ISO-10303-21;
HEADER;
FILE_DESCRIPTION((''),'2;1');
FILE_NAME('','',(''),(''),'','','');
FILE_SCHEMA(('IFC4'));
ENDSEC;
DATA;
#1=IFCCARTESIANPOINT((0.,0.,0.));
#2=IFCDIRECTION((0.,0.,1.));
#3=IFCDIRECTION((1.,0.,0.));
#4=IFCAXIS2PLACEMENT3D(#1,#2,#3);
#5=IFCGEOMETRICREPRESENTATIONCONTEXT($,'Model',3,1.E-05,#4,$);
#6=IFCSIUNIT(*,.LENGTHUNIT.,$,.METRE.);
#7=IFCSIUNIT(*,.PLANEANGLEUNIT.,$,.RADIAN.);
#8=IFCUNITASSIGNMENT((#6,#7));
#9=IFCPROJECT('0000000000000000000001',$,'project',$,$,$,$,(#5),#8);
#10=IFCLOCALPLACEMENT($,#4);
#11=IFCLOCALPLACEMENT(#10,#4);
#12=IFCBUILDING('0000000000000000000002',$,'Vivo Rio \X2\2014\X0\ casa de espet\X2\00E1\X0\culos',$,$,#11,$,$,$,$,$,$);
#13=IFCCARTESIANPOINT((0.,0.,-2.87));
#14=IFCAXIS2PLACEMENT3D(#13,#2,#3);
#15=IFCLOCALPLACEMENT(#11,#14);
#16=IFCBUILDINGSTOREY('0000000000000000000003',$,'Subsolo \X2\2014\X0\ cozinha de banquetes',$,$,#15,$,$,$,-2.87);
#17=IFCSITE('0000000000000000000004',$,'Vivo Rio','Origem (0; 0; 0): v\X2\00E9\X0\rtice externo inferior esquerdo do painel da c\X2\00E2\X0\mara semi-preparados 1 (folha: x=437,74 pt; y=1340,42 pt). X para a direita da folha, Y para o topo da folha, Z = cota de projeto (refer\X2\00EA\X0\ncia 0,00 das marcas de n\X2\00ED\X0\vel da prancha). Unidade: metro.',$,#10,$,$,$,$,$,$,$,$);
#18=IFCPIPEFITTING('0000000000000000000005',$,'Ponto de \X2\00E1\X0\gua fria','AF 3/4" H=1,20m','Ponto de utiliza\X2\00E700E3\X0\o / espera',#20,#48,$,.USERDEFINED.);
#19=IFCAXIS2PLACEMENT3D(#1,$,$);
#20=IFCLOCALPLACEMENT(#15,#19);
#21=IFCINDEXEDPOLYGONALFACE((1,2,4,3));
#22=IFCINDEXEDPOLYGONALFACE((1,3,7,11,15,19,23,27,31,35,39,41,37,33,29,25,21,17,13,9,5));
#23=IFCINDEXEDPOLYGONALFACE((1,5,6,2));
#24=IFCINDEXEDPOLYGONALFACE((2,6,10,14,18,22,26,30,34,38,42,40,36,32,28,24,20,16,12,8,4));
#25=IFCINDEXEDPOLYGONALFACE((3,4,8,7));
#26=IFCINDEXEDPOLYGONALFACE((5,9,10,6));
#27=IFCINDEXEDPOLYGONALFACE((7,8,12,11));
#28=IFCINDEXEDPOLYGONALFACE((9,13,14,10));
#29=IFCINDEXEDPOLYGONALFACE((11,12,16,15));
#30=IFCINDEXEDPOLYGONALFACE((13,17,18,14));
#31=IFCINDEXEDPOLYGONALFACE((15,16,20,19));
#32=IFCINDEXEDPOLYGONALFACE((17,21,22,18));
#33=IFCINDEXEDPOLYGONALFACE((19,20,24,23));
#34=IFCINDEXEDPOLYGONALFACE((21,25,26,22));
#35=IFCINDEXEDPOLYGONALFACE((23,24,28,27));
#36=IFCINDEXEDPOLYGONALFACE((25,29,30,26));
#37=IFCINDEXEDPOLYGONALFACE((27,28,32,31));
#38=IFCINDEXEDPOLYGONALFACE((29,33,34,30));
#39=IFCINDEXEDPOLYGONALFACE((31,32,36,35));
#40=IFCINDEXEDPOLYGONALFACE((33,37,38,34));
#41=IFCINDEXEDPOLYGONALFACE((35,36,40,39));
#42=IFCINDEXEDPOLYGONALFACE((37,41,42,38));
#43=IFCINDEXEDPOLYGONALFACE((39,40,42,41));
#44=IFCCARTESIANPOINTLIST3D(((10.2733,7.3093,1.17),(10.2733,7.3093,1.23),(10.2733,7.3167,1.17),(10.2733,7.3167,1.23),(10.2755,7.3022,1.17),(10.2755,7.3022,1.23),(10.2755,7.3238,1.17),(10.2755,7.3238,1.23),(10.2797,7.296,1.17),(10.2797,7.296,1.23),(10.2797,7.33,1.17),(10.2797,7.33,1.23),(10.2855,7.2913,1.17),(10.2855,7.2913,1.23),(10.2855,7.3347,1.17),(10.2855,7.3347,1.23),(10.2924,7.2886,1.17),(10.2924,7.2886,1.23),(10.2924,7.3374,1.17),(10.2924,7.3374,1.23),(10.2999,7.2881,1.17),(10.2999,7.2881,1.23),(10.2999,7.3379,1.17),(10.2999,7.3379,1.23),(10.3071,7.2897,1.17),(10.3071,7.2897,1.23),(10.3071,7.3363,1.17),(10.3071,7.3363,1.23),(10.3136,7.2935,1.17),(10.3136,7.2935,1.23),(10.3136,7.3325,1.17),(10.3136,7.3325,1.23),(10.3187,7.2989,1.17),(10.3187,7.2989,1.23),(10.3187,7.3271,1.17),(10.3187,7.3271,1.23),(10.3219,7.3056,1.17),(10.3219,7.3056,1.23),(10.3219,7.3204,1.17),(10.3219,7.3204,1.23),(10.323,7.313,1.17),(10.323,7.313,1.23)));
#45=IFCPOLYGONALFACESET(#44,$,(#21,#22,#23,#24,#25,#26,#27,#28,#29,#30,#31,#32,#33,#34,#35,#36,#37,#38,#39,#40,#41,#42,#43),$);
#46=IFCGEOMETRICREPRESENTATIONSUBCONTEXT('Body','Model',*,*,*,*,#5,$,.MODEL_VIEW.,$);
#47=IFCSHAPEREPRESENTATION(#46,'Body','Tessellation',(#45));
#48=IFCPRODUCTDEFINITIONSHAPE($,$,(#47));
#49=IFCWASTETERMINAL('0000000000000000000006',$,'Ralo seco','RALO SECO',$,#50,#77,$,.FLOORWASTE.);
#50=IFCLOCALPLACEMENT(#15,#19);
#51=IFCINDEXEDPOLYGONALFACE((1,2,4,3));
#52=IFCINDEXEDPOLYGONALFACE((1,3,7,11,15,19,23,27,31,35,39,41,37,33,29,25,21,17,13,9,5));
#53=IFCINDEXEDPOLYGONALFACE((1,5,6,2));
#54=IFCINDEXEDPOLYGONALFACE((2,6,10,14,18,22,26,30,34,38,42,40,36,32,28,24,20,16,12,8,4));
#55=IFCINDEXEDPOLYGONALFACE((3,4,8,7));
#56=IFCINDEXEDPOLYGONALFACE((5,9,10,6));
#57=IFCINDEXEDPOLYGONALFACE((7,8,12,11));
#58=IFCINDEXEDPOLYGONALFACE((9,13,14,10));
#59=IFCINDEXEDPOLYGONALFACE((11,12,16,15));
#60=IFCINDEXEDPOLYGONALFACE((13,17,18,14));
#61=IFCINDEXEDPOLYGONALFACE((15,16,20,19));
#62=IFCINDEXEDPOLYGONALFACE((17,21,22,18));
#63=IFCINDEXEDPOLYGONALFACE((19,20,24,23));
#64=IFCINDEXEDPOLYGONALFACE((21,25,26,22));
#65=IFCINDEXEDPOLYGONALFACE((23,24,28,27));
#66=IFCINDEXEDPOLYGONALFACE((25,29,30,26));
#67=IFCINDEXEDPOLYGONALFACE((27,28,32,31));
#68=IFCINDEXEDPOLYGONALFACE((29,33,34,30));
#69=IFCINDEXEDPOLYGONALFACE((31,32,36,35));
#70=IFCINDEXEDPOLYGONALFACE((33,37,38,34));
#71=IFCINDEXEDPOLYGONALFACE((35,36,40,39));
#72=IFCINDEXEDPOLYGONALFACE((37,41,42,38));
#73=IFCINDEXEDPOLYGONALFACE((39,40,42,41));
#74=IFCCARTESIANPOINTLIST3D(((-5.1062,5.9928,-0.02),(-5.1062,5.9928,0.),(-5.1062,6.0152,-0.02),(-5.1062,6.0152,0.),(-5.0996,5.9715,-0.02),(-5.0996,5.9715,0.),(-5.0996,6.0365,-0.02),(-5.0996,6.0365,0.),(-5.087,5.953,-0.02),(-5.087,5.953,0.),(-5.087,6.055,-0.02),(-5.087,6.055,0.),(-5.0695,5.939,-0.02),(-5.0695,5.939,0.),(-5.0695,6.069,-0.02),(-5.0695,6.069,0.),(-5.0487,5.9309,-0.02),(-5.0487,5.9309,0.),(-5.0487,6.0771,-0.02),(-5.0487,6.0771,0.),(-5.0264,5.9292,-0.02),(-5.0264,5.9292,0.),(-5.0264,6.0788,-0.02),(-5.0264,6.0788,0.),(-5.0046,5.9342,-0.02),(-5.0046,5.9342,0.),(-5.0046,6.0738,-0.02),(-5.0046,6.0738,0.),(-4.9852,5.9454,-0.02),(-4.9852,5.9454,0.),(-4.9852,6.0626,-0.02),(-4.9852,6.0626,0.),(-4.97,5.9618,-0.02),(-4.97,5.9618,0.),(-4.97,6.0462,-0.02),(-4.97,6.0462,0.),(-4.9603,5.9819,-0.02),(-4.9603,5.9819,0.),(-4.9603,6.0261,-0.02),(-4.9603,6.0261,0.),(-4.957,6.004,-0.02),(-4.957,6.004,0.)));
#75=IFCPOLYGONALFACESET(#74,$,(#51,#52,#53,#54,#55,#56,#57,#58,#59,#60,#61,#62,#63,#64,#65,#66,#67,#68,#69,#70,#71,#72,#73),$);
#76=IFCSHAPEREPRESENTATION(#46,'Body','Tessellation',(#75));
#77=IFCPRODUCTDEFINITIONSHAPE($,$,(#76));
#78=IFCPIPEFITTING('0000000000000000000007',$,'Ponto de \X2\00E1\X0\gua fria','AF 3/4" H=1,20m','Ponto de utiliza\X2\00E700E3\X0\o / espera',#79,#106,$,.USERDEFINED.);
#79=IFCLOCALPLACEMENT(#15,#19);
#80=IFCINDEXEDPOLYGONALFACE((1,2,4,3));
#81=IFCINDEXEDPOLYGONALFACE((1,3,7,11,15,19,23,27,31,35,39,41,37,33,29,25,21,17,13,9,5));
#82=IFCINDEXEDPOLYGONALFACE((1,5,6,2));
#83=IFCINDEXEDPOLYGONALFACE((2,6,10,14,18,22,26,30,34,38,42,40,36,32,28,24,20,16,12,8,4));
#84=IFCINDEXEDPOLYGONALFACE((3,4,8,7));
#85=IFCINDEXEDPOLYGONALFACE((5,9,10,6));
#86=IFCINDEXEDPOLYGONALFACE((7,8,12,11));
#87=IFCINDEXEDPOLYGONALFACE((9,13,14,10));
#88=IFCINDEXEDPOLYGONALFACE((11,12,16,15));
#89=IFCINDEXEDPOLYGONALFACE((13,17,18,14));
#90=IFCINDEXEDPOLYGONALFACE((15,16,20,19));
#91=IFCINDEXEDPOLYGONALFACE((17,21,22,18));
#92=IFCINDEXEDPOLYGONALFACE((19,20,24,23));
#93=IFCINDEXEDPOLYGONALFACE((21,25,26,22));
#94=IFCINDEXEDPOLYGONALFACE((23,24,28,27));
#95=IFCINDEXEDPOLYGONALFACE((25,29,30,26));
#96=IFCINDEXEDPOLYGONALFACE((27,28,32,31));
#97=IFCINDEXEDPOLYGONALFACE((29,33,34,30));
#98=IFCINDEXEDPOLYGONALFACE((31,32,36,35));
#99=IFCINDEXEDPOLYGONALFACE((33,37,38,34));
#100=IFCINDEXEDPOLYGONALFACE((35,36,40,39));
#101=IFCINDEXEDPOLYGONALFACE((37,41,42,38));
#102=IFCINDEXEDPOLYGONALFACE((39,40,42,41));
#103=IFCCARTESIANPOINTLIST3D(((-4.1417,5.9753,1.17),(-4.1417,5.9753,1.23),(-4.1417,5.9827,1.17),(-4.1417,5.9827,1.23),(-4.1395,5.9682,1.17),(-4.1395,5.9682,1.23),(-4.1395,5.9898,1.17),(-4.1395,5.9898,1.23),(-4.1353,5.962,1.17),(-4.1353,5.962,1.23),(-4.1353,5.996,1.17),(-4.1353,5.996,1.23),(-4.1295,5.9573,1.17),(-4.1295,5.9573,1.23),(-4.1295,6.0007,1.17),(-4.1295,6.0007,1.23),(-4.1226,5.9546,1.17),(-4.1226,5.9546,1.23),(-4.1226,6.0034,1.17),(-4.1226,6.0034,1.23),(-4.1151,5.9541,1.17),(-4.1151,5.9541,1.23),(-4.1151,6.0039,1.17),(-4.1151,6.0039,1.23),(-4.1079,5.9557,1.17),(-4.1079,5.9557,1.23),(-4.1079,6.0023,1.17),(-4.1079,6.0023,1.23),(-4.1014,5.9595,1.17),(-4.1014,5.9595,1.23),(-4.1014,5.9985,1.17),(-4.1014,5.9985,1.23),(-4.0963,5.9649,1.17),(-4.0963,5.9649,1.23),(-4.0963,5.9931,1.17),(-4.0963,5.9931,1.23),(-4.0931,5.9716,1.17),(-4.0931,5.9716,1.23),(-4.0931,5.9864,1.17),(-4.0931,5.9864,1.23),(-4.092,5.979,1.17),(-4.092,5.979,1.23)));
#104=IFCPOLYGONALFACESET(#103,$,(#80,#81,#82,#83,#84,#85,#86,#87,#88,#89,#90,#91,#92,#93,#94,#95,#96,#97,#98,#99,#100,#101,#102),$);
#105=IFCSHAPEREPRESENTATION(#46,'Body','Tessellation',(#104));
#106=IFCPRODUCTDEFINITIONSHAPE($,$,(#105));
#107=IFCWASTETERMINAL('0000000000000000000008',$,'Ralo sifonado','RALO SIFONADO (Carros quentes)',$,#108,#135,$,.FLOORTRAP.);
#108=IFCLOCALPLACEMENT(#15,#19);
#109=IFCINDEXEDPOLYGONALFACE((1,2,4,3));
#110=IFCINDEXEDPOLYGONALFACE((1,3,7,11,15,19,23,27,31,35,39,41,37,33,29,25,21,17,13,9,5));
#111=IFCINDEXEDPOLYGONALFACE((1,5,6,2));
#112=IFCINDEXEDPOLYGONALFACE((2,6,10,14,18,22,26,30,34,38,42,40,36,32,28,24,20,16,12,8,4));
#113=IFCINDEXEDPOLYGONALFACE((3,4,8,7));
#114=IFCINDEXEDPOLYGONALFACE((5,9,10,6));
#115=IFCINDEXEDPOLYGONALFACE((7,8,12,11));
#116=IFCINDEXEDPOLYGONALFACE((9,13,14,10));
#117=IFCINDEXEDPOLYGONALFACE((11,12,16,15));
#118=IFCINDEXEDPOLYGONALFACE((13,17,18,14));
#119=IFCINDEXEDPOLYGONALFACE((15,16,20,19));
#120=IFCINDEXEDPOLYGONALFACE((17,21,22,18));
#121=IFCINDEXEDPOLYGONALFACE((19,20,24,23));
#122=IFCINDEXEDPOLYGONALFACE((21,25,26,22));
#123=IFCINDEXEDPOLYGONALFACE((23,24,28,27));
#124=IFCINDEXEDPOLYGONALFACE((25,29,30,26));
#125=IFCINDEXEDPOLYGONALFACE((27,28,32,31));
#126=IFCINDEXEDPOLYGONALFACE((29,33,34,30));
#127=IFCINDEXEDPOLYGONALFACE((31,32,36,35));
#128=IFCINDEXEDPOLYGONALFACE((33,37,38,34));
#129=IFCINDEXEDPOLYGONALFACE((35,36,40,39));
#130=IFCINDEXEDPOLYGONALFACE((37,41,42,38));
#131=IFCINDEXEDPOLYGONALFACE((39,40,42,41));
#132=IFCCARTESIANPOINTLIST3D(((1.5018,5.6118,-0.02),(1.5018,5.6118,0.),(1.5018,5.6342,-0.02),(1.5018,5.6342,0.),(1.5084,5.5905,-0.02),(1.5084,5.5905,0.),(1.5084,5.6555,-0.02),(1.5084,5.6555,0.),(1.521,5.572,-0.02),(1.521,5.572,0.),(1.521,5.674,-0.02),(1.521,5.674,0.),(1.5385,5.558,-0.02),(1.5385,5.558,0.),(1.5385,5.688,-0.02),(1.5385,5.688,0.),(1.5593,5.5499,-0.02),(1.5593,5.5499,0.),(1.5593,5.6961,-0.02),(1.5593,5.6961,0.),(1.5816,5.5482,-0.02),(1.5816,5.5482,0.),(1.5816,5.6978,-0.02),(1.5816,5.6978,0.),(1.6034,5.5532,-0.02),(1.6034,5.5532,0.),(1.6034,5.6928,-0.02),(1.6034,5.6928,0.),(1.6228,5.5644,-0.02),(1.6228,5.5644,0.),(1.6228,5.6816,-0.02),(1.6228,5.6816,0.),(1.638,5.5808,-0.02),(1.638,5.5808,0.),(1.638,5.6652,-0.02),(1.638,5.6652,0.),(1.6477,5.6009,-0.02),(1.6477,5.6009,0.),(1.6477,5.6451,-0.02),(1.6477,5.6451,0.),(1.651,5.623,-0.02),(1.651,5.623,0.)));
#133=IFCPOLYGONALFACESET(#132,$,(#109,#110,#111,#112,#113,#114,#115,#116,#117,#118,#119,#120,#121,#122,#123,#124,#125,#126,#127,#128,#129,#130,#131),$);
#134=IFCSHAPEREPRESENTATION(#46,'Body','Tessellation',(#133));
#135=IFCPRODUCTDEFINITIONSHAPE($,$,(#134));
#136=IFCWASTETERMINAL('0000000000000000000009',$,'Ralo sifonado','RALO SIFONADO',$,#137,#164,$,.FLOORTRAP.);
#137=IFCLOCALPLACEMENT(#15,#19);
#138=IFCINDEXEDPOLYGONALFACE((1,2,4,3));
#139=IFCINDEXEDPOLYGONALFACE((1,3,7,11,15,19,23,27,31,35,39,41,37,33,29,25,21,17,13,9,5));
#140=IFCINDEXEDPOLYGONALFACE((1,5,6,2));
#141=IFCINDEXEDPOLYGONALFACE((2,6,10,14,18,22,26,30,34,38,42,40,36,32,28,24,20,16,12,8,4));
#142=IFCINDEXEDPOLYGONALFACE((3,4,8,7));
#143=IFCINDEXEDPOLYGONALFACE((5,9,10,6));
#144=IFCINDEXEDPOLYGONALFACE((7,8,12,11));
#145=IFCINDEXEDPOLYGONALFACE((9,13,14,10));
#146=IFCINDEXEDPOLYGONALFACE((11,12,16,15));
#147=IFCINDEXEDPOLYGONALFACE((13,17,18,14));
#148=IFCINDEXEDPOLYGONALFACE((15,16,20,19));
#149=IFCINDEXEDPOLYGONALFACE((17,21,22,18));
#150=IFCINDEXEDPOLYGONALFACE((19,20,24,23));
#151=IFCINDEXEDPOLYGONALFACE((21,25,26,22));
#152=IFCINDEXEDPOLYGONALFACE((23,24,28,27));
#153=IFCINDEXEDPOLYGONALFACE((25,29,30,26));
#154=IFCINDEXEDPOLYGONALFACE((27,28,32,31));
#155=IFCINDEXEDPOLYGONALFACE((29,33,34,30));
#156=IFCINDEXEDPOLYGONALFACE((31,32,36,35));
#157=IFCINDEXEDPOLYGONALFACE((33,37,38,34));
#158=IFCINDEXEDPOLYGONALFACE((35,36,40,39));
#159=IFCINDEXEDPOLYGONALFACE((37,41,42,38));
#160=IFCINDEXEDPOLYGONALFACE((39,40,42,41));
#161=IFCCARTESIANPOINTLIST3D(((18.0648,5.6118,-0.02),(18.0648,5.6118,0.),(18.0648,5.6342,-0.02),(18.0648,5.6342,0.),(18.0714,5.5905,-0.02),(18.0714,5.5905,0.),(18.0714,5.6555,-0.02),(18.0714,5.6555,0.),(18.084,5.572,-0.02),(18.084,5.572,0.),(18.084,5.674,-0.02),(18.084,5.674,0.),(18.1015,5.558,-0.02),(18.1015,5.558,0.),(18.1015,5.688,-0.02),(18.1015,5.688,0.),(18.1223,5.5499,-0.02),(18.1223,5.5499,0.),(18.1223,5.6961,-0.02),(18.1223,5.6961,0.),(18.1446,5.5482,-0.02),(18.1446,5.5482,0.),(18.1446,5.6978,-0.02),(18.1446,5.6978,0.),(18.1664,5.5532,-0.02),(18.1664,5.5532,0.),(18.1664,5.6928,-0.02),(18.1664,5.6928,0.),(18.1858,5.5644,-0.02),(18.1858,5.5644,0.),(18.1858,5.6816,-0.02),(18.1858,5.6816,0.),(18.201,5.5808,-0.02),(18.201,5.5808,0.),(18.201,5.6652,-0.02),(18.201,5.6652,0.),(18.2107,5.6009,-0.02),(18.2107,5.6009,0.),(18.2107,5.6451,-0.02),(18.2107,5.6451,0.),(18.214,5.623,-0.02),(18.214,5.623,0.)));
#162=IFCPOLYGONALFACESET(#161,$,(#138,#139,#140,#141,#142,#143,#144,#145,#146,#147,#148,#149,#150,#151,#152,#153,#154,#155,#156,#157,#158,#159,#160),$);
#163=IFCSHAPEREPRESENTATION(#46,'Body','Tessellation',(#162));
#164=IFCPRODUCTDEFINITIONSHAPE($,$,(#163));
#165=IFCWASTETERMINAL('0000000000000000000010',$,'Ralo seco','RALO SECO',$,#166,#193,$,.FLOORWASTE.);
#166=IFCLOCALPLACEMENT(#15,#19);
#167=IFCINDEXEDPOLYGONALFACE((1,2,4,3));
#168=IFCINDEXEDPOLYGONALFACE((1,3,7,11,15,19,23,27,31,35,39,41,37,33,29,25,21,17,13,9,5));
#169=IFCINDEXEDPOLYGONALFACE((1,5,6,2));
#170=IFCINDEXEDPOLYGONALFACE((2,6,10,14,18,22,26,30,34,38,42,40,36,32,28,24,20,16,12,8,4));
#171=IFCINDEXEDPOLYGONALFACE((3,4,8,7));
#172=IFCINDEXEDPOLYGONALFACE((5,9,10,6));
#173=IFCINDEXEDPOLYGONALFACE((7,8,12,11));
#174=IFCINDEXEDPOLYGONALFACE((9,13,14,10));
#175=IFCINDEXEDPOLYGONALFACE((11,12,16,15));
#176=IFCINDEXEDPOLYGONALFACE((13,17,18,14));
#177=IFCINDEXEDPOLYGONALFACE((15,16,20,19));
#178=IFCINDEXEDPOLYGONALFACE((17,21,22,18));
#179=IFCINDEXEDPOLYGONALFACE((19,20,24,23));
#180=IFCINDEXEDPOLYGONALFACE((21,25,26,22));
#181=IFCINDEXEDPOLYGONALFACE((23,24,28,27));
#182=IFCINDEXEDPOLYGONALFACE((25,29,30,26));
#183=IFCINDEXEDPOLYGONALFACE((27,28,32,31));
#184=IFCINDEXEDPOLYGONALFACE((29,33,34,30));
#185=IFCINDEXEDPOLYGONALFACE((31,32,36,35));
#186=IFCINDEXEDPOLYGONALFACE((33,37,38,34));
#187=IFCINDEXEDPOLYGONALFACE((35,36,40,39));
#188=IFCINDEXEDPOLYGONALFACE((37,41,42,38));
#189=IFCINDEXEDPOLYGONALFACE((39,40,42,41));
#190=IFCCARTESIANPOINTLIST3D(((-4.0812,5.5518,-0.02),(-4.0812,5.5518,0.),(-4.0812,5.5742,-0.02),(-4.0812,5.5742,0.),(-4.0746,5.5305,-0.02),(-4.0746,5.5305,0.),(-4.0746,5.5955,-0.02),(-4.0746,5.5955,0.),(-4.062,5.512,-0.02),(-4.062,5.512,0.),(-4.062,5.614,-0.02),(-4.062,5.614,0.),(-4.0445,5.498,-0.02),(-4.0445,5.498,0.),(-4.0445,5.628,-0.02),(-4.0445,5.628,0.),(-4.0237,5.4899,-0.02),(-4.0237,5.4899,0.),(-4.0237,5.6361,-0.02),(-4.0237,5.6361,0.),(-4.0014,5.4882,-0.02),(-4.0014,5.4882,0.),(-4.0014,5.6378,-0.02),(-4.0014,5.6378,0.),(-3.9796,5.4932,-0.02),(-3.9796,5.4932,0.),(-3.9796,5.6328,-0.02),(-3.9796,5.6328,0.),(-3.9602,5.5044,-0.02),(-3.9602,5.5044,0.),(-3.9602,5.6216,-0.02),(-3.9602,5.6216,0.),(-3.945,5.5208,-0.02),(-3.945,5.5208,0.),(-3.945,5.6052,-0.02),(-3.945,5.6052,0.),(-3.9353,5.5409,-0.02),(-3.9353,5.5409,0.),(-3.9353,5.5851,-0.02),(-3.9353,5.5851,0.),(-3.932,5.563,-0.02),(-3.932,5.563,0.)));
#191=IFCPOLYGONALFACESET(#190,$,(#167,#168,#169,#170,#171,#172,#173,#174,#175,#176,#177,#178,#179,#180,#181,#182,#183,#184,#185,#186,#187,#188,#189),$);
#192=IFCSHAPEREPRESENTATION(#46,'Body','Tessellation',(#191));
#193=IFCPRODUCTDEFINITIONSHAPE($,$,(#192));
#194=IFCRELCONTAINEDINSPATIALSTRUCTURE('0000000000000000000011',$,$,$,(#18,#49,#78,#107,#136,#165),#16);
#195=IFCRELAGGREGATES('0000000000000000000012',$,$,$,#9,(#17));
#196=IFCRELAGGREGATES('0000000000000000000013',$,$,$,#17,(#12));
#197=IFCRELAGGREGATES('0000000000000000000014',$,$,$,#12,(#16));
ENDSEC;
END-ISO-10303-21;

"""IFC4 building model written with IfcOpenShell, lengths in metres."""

from ifc_helpers import new_model, si_unit, frame, origin_with_axes, origin_2d, place, context, subcontext, project, spatial, circle, extrude, element, save


model = new_model("IFC4")

# Units and contexts
model_context = context("Model", 3, precision=1e-05, world=origin_with_axes())
body_context = subcontext(model_context, "Body", "Model", "MODEL_VIEW")
ifc_project = project(units=[si_unit("LENGTHUNIT", "METRE"), si_unit("PLANEANGLEUNIT", "RADIAN")], contexts=[model_context])

# Site, building, storey
site_placement = place(None, origin_with_axes())
site = spatial("IfcSite", under=ifc_project, at=site_placement, Name="Vivo Rio", Description="Origem (0; 0; 0): vértice externo inferior esquerdo do painel da câmara semi-preparados 1 (folha: x=437,74 pt; y=1340,42 pt). X para a direita da folha, Y para o topo da folha, Z = cota de projeto (referência 0,00 das marcas de nível da prancha). Unidade: metro.")
building_placement = place(site_placement, origin_with_axes())
building = spatial("IfcBuilding", under=site, at=building_placement, Name="Vivo Rio — casa de espetáculos")
storey_placement = place(building_placement, frame((0.0, 0.0, -2.87), z_axis=(0.0, 0.0, 1.0), x_axis=(1.0, 0.0, 0.0)))
storey = spatial("IfcBuildingStorey", under=building, at=storey_placement, Name="Subsolo — cozinha de banquetes", Elevation=-2.87)

# Pipe fitting
pipe_fitting_1_placement = place(storey_placement, origin_with_axes())
element("IfcPipeFitting", 1, at=pipe_fitting_1_placement, inside=storey, Name="Ponto de água fria", Description="AF 3/4\" H=1,20m", ObjectType="Ponto de utilização / espera", PredefinedType="USERDEFINED", context=body_context, shape_type="SweptSolid", body=[
    extrude(circle(Radius=0.025, at=origin_2d()), frame((10.298, 7.313, 1.17), z_axis=(0.0, 0.0, 1.0), x_axis=(1.0, 0.0, 0.0)), (0.0, 0.0, 1.0), 0.06),
])

# Waste terminal
waste_terminal_1_placement = place(storey_placement, origin_with_axes())
element("IfcWasteTerminal", 2, at=waste_terminal_1_placement, inside=storey, Name="Ralo seco", Description="RALO SECO", PredefinedType="FLOORWASTE", context=body_context, shape_type="SweptSolid", body=[
    extrude(circle(Radius=0.075, at=origin_2d()), frame((-5.032, 6.004, -0.02), z_axis=(0.0, 0.0, 1.0), x_axis=(1.0, 0.0, 0.0)), (0.0, 0.0, 1.0), 0.02),
])

# Pipe fitting
pipe_fitting_2_placement = place(storey_placement, origin_with_axes())
element("IfcPipeFitting", 3, at=pipe_fitting_2_placement, inside=storey, Name="Ponto de água fria", Description="AF 3/4\" H=1,20m", ObjectType="Ponto de utilização / espera", PredefinedType="USERDEFINED", context=body_context, shape_type="SweptSolid", body=[
    extrude(circle(Radius=0.025, at=origin_2d()), frame((-4.117, 5.979, 1.17), z_axis=(0.0, 0.0, 1.0), x_axis=(1.0, 0.0, 0.0)), (0.0, 0.0, 1.0), 0.06),
])

# Waste terminals
waste_terminal_2_placement = place(storey_placement, origin_with_axes())
element("IfcWasteTerminal", 4, at=waste_terminal_2_placement, inside=storey, Name="Ralo sifonado", Description="RALO SIFONADO (Carros quentes)", PredefinedType="FLOORTRAP", context=body_context, shape_type="SweptSolid", body=[
    extrude(circle(Radius=0.075, at=origin_2d()), frame((1.576, 5.623, -0.02), z_axis=(0.0, 0.0, 1.0), x_axis=(1.0, 0.0, 0.0)), (0.0, 0.0, 1.0), 0.02),
])
waste_terminal_3_placement = place(storey_placement, origin_with_axes())
element("IfcWasteTerminal", 5, at=waste_terminal_3_placement, inside=storey, Name="Ralo sifonado", Description="RALO SIFONADO", PredefinedType="FLOORTRAP", context=body_context, shape_type="SweptSolid", body=[
    extrude(circle(Radius=0.075, at=origin_2d()), frame((18.139, 5.623, -0.02), z_axis=(0.0, 0.0, 1.0), x_axis=(1.0, 0.0, 0.0)), (0.0, 0.0, 1.0), 0.02),
])
waste_terminal_4_placement = place(storey_placement, origin_with_axes())
element("IfcWasteTerminal", 6, at=waste_terminal_4_placement, inside=storey, Name="Ralo seco", Description="RALO SECO", PredefinedType="FLOORWASTE", context=body_context, shape_type="SweptSolid", body=[
    extrude(circle(Radius=0.075, at=origin_2d()), frame((-4.007, 5.563, -0.02), z_axis=(0.0, 0.0, 1.0), x_axis=(1.0, 0.0, 0.0)), (0.0, 0.0, 1.0), 0.02),
])

save(model, "model.ifc")
